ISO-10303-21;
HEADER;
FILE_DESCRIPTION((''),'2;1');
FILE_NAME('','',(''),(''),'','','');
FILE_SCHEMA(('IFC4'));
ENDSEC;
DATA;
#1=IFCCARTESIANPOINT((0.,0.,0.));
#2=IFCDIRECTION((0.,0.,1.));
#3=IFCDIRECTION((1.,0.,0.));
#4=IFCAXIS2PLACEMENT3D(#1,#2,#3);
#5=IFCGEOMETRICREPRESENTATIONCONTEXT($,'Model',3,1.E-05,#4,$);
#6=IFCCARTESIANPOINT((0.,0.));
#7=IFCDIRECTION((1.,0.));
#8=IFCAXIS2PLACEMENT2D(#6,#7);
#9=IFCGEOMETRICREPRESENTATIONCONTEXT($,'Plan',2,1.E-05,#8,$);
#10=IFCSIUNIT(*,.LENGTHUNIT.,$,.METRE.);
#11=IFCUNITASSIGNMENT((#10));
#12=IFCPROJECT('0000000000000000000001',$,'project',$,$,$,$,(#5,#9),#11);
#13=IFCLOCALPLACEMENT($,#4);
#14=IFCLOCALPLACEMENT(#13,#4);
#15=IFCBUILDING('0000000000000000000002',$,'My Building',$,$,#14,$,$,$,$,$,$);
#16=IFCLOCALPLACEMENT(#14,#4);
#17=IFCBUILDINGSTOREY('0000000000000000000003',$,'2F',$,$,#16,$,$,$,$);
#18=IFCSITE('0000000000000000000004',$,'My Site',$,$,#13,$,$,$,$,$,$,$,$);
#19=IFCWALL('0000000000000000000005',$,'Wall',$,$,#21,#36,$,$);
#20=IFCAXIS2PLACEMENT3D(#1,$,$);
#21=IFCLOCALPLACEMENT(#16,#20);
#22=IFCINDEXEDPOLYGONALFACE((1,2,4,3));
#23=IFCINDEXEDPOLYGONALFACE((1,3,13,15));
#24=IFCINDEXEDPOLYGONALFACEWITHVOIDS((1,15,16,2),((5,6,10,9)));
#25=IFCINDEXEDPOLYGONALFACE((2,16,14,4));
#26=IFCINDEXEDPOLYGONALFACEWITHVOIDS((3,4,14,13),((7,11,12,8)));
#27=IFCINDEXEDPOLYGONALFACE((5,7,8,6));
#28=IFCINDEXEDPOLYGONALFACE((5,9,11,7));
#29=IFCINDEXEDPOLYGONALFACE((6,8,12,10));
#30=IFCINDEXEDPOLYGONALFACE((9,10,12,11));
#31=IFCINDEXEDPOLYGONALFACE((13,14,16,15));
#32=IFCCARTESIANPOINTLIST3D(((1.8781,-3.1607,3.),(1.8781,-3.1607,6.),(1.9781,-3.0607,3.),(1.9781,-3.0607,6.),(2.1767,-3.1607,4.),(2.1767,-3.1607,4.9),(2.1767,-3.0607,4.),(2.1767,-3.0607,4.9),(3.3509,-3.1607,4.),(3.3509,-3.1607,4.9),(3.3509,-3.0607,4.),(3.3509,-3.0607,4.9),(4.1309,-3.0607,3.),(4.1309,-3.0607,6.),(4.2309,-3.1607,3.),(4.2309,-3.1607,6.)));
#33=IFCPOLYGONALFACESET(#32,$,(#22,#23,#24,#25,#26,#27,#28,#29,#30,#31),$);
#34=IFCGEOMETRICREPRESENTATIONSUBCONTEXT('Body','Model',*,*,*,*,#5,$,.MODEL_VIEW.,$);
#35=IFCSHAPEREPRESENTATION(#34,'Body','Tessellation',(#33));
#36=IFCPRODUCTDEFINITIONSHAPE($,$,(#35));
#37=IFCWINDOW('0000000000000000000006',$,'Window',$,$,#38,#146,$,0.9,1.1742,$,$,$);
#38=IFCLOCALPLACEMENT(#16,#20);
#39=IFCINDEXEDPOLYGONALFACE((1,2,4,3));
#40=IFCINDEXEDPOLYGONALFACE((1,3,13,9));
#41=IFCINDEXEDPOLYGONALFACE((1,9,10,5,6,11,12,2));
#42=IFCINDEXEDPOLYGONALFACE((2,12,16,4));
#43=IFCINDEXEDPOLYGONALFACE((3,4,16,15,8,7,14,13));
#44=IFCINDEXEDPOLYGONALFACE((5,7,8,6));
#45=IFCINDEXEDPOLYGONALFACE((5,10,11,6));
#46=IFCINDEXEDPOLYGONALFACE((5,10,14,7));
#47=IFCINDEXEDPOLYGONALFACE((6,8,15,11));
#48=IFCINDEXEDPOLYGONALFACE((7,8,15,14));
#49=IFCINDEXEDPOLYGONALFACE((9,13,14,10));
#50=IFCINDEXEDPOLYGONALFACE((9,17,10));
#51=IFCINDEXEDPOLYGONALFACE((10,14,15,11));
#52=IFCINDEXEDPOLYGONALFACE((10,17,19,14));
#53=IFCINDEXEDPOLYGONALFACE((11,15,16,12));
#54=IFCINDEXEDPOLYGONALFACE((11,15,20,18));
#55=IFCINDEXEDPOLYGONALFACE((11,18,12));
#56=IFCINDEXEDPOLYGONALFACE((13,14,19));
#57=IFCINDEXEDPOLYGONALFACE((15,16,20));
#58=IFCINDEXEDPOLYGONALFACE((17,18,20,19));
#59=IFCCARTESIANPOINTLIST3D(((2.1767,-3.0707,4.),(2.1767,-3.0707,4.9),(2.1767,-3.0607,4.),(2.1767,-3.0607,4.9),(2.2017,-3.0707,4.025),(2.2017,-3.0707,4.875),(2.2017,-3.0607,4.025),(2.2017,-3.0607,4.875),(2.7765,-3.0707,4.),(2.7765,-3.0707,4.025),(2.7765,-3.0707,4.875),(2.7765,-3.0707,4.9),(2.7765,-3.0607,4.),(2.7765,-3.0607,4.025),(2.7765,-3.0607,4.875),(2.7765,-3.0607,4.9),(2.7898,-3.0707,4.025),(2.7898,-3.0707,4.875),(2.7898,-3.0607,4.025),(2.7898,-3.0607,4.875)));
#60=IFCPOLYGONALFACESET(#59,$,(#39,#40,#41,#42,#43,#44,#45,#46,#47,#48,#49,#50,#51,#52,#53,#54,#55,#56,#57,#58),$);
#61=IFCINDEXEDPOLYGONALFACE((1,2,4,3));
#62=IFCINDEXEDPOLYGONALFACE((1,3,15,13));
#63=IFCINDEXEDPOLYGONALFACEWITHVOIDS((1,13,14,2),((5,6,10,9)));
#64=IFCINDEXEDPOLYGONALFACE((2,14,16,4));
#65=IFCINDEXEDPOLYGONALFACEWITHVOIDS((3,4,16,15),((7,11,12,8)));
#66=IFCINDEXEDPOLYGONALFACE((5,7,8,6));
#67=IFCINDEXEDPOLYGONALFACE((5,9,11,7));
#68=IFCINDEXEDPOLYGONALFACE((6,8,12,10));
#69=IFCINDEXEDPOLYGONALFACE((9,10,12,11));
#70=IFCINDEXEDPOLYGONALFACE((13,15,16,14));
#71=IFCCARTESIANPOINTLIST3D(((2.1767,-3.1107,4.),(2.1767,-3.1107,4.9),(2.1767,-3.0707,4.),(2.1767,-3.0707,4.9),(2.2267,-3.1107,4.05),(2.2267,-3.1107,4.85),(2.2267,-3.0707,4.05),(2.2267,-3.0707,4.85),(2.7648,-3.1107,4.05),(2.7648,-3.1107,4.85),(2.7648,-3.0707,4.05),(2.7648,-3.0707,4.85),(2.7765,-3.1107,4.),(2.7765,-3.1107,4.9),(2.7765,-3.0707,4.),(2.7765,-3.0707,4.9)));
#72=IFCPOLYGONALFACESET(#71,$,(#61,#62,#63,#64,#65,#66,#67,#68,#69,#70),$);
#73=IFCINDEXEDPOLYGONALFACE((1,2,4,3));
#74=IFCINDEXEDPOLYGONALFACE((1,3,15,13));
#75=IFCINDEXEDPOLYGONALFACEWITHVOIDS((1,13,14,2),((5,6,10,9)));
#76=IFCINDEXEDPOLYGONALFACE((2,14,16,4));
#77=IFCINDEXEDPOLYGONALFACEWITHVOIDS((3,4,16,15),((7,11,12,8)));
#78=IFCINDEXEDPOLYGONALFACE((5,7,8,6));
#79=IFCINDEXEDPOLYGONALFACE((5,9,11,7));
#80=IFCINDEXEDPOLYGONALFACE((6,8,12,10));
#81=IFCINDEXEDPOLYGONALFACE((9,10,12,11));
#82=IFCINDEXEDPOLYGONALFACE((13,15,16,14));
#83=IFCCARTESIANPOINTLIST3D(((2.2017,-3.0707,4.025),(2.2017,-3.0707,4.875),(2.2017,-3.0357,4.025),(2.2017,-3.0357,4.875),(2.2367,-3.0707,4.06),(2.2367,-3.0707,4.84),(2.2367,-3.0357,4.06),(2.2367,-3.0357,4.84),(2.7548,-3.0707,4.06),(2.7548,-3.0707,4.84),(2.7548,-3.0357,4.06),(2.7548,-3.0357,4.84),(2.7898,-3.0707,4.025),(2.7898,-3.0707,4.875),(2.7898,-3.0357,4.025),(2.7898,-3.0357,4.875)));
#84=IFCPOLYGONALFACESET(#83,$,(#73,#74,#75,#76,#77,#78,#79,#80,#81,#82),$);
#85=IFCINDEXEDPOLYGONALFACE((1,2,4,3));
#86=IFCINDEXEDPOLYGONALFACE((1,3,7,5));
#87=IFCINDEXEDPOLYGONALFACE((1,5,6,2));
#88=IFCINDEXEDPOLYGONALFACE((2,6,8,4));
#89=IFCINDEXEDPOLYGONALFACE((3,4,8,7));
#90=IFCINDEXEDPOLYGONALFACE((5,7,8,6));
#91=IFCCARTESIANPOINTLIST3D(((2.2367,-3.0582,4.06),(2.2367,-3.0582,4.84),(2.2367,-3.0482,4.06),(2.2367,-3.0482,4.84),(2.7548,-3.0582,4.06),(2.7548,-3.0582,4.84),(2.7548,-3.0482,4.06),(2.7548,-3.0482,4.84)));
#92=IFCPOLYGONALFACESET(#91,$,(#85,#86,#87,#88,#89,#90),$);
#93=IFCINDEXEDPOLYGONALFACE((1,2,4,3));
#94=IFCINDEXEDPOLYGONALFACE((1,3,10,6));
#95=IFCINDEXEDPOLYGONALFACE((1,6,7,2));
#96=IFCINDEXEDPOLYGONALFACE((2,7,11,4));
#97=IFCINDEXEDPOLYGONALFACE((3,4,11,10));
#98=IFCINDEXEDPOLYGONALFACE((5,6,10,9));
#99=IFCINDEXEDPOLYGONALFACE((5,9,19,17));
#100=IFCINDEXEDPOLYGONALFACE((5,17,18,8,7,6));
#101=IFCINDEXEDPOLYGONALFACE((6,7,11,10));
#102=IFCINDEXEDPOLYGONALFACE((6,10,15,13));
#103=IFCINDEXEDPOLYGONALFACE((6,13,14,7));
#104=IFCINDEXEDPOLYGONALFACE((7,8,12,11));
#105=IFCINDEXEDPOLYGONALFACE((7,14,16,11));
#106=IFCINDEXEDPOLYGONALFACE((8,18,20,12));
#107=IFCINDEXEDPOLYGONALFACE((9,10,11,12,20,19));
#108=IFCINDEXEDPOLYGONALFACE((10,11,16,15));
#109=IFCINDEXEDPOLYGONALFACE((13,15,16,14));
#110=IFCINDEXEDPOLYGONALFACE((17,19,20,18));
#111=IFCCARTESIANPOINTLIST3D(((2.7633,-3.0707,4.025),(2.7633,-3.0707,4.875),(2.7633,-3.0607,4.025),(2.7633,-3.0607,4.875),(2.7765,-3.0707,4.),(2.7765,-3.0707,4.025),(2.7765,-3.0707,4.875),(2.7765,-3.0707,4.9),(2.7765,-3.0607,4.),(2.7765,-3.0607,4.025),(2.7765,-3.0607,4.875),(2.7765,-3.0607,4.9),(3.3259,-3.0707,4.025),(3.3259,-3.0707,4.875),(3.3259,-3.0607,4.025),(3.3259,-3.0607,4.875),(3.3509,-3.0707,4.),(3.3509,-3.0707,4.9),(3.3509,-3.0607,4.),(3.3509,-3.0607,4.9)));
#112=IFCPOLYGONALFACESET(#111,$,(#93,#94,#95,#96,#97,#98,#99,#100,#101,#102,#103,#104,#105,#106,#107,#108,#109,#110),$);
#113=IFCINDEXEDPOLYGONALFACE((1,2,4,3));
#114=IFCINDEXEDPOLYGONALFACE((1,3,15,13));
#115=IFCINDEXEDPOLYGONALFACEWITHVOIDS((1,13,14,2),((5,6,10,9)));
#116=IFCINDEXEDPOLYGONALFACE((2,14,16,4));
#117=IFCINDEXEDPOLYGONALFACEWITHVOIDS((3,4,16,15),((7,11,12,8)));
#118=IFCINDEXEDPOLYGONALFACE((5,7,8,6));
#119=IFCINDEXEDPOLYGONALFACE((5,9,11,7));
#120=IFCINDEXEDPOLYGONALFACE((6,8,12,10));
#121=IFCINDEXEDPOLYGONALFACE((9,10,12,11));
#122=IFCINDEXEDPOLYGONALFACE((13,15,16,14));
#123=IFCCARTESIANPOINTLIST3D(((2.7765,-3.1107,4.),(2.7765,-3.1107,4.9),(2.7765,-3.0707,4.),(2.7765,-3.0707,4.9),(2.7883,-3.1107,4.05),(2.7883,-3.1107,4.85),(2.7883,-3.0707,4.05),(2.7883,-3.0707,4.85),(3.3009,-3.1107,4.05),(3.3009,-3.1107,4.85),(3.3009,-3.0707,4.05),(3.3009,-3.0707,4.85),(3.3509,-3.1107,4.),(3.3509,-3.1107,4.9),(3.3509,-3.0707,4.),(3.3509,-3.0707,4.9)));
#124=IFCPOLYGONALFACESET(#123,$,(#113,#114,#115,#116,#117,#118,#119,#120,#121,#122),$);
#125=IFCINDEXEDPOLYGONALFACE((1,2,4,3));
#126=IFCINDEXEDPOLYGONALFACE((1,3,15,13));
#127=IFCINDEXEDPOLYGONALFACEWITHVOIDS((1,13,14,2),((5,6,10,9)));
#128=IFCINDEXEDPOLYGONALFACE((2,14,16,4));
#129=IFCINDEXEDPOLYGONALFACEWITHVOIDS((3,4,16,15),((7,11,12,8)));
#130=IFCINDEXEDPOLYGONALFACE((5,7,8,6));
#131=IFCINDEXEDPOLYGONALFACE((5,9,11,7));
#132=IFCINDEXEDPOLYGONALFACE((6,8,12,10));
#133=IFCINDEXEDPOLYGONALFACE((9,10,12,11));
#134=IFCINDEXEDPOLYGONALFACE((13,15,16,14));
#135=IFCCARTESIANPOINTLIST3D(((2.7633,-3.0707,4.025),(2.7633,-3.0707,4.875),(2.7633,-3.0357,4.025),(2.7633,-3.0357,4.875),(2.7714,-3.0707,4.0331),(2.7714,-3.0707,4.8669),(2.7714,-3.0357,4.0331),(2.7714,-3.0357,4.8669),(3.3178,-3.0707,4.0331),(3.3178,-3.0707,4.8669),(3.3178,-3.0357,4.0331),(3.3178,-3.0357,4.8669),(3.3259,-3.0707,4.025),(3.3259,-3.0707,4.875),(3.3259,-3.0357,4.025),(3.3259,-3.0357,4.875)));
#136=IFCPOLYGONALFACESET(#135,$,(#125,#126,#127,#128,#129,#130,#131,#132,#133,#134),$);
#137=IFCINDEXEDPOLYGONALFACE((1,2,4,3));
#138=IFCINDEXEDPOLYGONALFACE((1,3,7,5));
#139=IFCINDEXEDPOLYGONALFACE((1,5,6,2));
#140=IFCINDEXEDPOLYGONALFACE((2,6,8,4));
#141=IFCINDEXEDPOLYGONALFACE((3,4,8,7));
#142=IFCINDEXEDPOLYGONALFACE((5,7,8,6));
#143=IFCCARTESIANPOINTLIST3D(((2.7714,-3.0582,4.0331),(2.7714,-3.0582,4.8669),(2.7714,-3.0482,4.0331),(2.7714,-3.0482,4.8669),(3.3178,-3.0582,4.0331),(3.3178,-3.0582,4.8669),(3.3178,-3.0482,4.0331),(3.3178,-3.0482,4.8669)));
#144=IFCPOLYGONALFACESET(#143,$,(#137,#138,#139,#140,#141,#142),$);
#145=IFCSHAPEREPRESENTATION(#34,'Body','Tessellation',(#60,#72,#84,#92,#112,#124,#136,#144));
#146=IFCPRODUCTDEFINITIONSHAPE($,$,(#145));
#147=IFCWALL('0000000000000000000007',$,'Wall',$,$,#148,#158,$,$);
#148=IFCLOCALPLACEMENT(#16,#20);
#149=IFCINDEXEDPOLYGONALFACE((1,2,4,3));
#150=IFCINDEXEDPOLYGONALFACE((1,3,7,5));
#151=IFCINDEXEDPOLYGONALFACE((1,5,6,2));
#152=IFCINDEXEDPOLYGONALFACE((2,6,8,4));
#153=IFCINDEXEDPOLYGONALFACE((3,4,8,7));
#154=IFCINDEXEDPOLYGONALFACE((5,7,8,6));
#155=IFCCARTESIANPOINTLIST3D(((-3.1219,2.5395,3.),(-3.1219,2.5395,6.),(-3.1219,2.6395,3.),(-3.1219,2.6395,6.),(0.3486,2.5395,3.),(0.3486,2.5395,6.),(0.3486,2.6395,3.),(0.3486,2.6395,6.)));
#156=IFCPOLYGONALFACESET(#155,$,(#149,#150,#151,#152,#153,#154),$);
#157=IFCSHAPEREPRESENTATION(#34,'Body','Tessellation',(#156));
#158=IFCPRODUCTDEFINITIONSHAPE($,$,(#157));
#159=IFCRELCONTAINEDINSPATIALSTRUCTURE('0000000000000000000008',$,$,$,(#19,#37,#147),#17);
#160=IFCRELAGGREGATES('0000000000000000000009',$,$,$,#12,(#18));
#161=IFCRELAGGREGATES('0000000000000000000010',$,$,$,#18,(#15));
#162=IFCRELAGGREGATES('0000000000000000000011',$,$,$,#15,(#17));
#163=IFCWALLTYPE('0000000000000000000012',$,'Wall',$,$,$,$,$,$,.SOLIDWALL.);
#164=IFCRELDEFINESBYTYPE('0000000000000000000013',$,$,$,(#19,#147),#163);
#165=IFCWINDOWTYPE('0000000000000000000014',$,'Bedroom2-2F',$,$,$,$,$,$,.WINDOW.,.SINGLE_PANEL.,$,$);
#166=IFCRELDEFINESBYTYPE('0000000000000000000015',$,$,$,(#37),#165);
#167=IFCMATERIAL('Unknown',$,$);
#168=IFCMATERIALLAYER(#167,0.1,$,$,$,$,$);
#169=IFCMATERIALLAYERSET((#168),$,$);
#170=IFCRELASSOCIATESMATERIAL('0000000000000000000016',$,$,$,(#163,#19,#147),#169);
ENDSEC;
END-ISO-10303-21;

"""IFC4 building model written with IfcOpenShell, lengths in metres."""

from ifc_helpers import new_model, entity, si_unit, frame, origin_with_axes, origin_2d_with_axis, place, context, subcontext, project, spatial, line, indexed_curve, outline, extrude, shape, source, transform, mapped, material, layer, layer_set, layer_usage, type_object, type_shapes, element, fill, save


model = new_model("IFC4")

# Units and contexts
model_context = context("Model", 3, precision=1e-05, world=origin_with_axes())
plan_context = context("Plan", 2, precision=1e-05, world=origin_2d_with_axis())
body_context_1 = subcontext(model_context, "Body", "Model", "MODEL_VIEW")
body_context_2 = subcontext(plan_context, "Body", "Plan", "PLAN_VIEW")
ifc_project = project(units=[si_unit("LENGTHUNIT", "METRE")], contexts=[model_context, plan_context])

# Site, building, storey
site_placement = place(None, origin_with_axes())
site = spatial("IfcSite", under=ifc_project, at=site_placement, Name="My Site")
building_placement = place(site_placement, origin_with_axes())
building = spatial("IfcBuilding", under=site, at=building_placement, Name="My Building")
storey_placement = place(building_placement, origin_with_axes())
storey = spatial("IfcBuildingStorey", under=building, at=storey_placement, Name="2F")

# Shared definitions
ifc_material = material(Name="Unknown")

# Shared definitions
ifc_layer = layer(ifc_material, 0.1)
ifc_layer_set = layer_set([ifc_layer])
wall_type = type_object("IfcWallType", Name="Wall", PredefinedType="SOLIDWALL", material=ifc_layer_set)

# Wall, opening, window
ifc_layer_usage_1 = layer_usage(ifc_layer_set, "AXIS2", "POSITIVE", 0.0)
wall_1_placement = place(storey_placement, frame((1.8781, -3.1607, 3.0), z_axis=(0.0, 0.0, 1.0), x_axis=(1.0, 0.0, 0.0)))
wall_1 = element("IfcWall", 1, at=wall_1_placement, inside=storey, type_object=wall_type, material=ifc_layer_usage_1, Name="Wall", context=body_context_1, shape_type="SweptSolid", body=[
    extrude(outline(indexed_curve([(0.0, 0.0), (0.1, 0.1), (2.2528, 0.1), (2.3528, 0.0)], segments=[line(1, 2, 3, 4, 1)])), origin_with_axes(), (0.0, 0.0, 1.0), 3.0),
])
shared_shape_1 = source(origin_with_axes(), body_context_1, "Body", "SweptSolid", [
    extrude(outline(indexed_curve([(0.0, 0.0), (1.1742, 0.0), (1.1742, 0.9), (0.0, 0.9)], segments=[line(1, 2, 3, 4, 1)])), frame((0.0, -0.6, 0.0), z_axis=(0.0, -1.0, 0.0), x_axis=(1.0, 0.0, 0.0)), (0.0, 0.0, -1.0), 1.2),
])
opening_1_placement = place(wall_1_placement, frame((0.2985, 0.0, 1.0), z_axis=(0.0, 0.0, 1.0), x_axis=(1.0, 0.0, 0.0)))
opening_1 = element("IfcOpeningElement", 2, at=opening_1_placement, cuts=wall_1, PredefinedType="OPENING", context=body_context_1, shape_type="MappedRepresentation", body=[
    mapped(shared_shape_1, transform((0.0, 0.0, 0.0), x_axis=(1.0, 0.0, 0.0), y_axis=(0.0, 1.0, 0.0), z_axis=(0.0, 0.0, 1.0), scale=1.0)),
])
window_type = type_object("IfcWindowType", Name="Bedroom2-2F", PartitioningType="SINGLE_PANEL", PredefinedType="WINDOW")
shared_shape_2 = source(origin_with_axes(), body_context_1, "Body", "SweptSolid", [
    extrude(outline(indexed_curve([(0.0, 0.0), (0.5999, 0.0), (0.5999, 0.9), (0.0, 0.9)], segments=[line(1, 2, 3, 4, 1)]), holes=[indexed_curve([(0.025, 0.025), (0.6131, 0.025), (0.6131, 0.875), (0.025, 0.875)], segments=[line(1, 2, 3, 4, 1)])]), frame((0.0, 0.09, 0.0), z_axis=(0.0, -1.0, 0.0), x_axis=(1.0, 0.0, 0.0)), (0.0, 0.0, -1.0), 0.01),
    extrude(outline(indexed_curve([(0.0, 0.0), (0.5999, 0.0), (0.5999, 0.9), (0.0, 0.9)], segments=[line(1, 2, 3, 4, 1)]), holes=[indexed_curve([(0.05, 0.05), (0.5881, 0.05), (0.5881, 0.85), (0.05, 0.85)], segments=[line(1, 2, 3, 4, 1)])]), frame((0.0, 0.05, 0.0), z_axis=(0.0, -1.0, 0.0), x_axis=(1.0, 0.0, 0.0)), (0.0, 0.0, -1.0), 0.04),
    extrude(outline(indexed_curve([(0.0, 0.0), (0.5881, 0.0), (0.5881, 0.85), (0.0, 0.85)], segments=[line(1, 2, 3, 4, 1)]), holes=[indexed_curve([(0.035, 0.035), (0.5531, 0.035), (0.5531, 0.815), (0.035, 0.815)], segments=[line(1, 2, 3, 4, 1)])]), frame((0.025, 0.09, 0.025), z_axis=(0.0, -1.0, 0.0), x_axis=(1.0, 0.0, 0.0)), (0.0, 0.0, -1.0), 0.035),
    extrude(outline(indexed_curve([(0.035, 0.035), (0.5531, 0.035), (0.5531, 0.815), (0.035, 0.815)], segments=[line(1, 2, 3, 4, 1)])), frame((0.025, 0.1025, 0.025), z_axis=(0.0, -1.0, 0.0), x_axis=(1.0, 0.0, 0.0)), (0.0, 0.0, -1.0), 0.01),
    extrude(outline(indexed_curve([(0.0, 0.0), (0.5744, 0.0), (0.5744, 0.9), (0.0, 0.9)], segments=[line(1, 2, 3, 4, 1)]), holes=[indexed_curve([(-0.0132, 0.025), (0.5494, 0.025), (0.5494, 0.875), (-0.0132, 0.875)], segments=[line(1, 2, 3, 4, 1)])]), frame((0.5999, 0.09, 0.0), z_axis=(0.0, -1.0, 0.0), x_axis=(1.0, 0.0, 0.0)), (0.0, 0.0, -1.0), 0.01),
    extrude(outline(indexed_curve([(0.0, 0.0), (0.5744, 0.0), (0.5744, 0.9), (0.0, 0.9)], segments=[line(1, 2, 3, 4, 1)]), holes=[indexed_curve([(0.0118, 0.05), (0.5244, 0.05), (0.5244, 0.85), (0.0118, 0.85)], segments=[line(1, 2, 3, 4, 1)])]), frame((0.5999, 0.05, 0.0), z_axis=(0.0, -1.0, 0.0), x_axis=(1.0, 0.0, 0.0)), (0.0, 0.0, -1.0), 0.04),
    extrude(outline(indexed_curve([(0.0, 0.0), (0.5626, 0.0), (0.5626, 0.85), (0.0, 0.85)], segments=[line(1, 2, 3, 4, 1)]), holes=[indexed_curve([(0.0081, 0.0081), (0.5545, 0.0081), (0.5545, 0.8419), (0.0081, 0.8419)], segments=[line(1, 2, 3, 4, 1)])]), frame((0.5866, 0.09, 0.025), z_axis=(0.0, -1.0, 0.0), x_axis=(1.0, 0.0, 0.0)), (0.0, 0.0, -1.0), 0.035),
    extrude(outline(indexed_curve([(0.0081, 0.0081), (0.5545, 0.0081), (0.5545, 0.8419), (0.0081, 0.8419)], segments=[line(1, 2, 3, 4, 1)])), frame((0.5866, 0.1025, 0.025), z_axis=(0.0, -1.0, 0.0), x_axis=(1.0, 0.0, 0.0)), (0.0, 0.0, -1.0), 0.01),
])
shared_shape_3 = source(origin_with_axes(), body_context_2, "Body", "Curve2D", [
    entity("IfcIndexedPolyCurve", entity("IfcCartesianPointList2D", [[0.05, 0.05], [0.5881, 0.05]])),
    entity("IfcIndexedPolyCurve", entity("IfcCartesianPointList2D", [[0.0, 0.1], [0.025, 0.1], [0.025, 0.09], [0.05, 0.09], [0.05, 0.05], [0.0, 0.05]]), [entity("IfcLineIndex", [1, 2, 3, 4, 5, 6, 1])]),
    entity("IfcIndexedPolyCurve", entity("IfcCartesianPointList2D", [[0.5999, 0.1], [0.6131, 0.1], [0.6131, 0.09], [0.5881, 0.09], [0.5881, 0.05], [0.5999, 0.05]])),
    entity("IfcIndexedPolyCurve", entity("IfcCartesianPointList2D", [[0.025, 0.09], [0.06, 0.09], [0.06, 0.125], [0.025, 0.125]]), [entity("IfcLineIndex", [1, 2, 3, 4, 1])]),
    entity("IfcIndexedPolyCurve", entity("IfcCartesianPointList2D", [[0.6131, 0.09], [0.5781, 0.09], [0.5781, 0.125], [0.6131, 0.125]]), [entity("IfcLineIndex", [1, 2, 3, 4, 1])]),
    entity("IfcIndexedPolyCurve", entity("IfcCartesianPointList2D", [[0.06, 0.09], [0.5781, 0.09]])),
    entity("IfcIndexedPolyCurve", entity("IfcCartesianPointList2D", [[0.06, 0.125], [0.5781, 0.125]])),
    entity("IfcIndexedPolyCurve", entity("IfcCartesianPointList2D", [[0.06, 0.1075], [0.5781, 0.1075]])),
    entity("IfcIndexedPolyCurve", entity("IfcCartesianPointList2D", [[0.6116, 0.05], [1.1242, 0.05]])),
    entity("IfcIndexedPolyCurve", entity("IfcCartesianPointList2D", [[0.5999, 0.1], [0.5866, 0.1], [0.5866, 0.09], [0.6116, 0.09], [0.6116, 0.05], [0.5999, 0.05]])),
    entity("IfcIndexedPolyCurve", entity("IfcCartesianPointList2D", [[1.1742, 0.1], [1.1492, 0.1], [1.1492, 0.09], [1.1242, 0.09], [1.1242, 0.05], [1.1742, 0.05]]), [entity("IfcLineIndex", [1, 2, 3, 4, 5, 6, 1])]),
    entity("IfcIndexedPolyCurve", entity("IfcCartesianPointList2D", [[0.5866, 0.09], [0.5947, 0.09], [0.5947, 0.125], [0.5866, 0.125]]), [entity("IfcLineIndex", [1, 2, 3, 4, 1])]),
    entity("IfcIndexedPolyCurve", entity("IfcCartesianPointList2D", [[1.1492, 0.09], [1.1412, 0.09], [1.1412, 0.125], [1.1492, 0.125]]), [entity("IfcLineIndex", [1, 2, 3, 4, 1])]),
    entity("IfcIndexedPolyCurve", entity("IfcCartesianPointList2D", [[0.5947, 0.09], [1.1412, 0.09]])),
    entity("IfcIndexedPolyCurve", entity("IfcCartesianPointList2D", [[0.5947, 0.125], [1.1412, 0.125]])),
    entity("IfcIndexedPolyCurve", entity("IfcCartesianPointList2D", [[0.5947, 0.1075], [1.1412, 0.1075]])),
])
type_shapes(window_type, [shared_shape_2, shared_shape_3])
window_placement = place(opening_1_placement, frame((0.0, 0.0, 0.0), z_axis=(0.0, 0.0, 1.0), x_axis=(1.0, 0.0, 0.0)))
window = element("IfcWindow", 3, at=window_placement, inside=storey, type_object=window_type, Name="Window", OverallHeight=0.9, OverallWidth=1.1742, shapes=[
    shape(body_context_1, "Body", "MappedRepresentation", [mapped(shared_shape_2, transform((0.0, 0.0, 0.0), x_axis=(1.0, 0.0, 0.0), y_axis=(0.0, 1.0, 0.0), z_axis=(0.0, 0.0, 1.0), scale=1.0))]),
    shape(body_context_2, "Body", "MappedRepresentation", [mapped(shared_shape_3, transform((0.0, 0.0, 0.0), x_axis=(1.0, 0.0, 0.0), y_axis=(0.0, 1.0, 0.0), z_axis=(0.0, 0.0, 1.0), scale=1.0))]),
])
fill(opening_1, window)

# Wall
ifc_layer_usage_2 = layer_usage(ifc_layer_set, "AXIS2", "POSITIVE", 0.0)
wall_2_placement = place(storey_placement, frame((0.3486, 2.6395, 3.0), z_axis=(0.0, 0.0, 1.0), x_axis=(-1.0, 0.0, 0.0)))
element("IfcWall", 4, at=wall_2_placement, inside=storey, type_object=wall_type, material=ifc_layer_usage_2, Name="Wall", context=body_context_1, shape_type="SweptSolid", body=[
    extrude(outline(indexed_curve([(0.0, 0.0), (0.0, 0.1), (3.4705, 0.1), (3.4705, 0.0)], segments=[line(1, 2, 3, 4, 1)])), origin_with_axes(), (0.0, 0.0, 1.0), 3.0),
])

save(model, "model.ifc")
